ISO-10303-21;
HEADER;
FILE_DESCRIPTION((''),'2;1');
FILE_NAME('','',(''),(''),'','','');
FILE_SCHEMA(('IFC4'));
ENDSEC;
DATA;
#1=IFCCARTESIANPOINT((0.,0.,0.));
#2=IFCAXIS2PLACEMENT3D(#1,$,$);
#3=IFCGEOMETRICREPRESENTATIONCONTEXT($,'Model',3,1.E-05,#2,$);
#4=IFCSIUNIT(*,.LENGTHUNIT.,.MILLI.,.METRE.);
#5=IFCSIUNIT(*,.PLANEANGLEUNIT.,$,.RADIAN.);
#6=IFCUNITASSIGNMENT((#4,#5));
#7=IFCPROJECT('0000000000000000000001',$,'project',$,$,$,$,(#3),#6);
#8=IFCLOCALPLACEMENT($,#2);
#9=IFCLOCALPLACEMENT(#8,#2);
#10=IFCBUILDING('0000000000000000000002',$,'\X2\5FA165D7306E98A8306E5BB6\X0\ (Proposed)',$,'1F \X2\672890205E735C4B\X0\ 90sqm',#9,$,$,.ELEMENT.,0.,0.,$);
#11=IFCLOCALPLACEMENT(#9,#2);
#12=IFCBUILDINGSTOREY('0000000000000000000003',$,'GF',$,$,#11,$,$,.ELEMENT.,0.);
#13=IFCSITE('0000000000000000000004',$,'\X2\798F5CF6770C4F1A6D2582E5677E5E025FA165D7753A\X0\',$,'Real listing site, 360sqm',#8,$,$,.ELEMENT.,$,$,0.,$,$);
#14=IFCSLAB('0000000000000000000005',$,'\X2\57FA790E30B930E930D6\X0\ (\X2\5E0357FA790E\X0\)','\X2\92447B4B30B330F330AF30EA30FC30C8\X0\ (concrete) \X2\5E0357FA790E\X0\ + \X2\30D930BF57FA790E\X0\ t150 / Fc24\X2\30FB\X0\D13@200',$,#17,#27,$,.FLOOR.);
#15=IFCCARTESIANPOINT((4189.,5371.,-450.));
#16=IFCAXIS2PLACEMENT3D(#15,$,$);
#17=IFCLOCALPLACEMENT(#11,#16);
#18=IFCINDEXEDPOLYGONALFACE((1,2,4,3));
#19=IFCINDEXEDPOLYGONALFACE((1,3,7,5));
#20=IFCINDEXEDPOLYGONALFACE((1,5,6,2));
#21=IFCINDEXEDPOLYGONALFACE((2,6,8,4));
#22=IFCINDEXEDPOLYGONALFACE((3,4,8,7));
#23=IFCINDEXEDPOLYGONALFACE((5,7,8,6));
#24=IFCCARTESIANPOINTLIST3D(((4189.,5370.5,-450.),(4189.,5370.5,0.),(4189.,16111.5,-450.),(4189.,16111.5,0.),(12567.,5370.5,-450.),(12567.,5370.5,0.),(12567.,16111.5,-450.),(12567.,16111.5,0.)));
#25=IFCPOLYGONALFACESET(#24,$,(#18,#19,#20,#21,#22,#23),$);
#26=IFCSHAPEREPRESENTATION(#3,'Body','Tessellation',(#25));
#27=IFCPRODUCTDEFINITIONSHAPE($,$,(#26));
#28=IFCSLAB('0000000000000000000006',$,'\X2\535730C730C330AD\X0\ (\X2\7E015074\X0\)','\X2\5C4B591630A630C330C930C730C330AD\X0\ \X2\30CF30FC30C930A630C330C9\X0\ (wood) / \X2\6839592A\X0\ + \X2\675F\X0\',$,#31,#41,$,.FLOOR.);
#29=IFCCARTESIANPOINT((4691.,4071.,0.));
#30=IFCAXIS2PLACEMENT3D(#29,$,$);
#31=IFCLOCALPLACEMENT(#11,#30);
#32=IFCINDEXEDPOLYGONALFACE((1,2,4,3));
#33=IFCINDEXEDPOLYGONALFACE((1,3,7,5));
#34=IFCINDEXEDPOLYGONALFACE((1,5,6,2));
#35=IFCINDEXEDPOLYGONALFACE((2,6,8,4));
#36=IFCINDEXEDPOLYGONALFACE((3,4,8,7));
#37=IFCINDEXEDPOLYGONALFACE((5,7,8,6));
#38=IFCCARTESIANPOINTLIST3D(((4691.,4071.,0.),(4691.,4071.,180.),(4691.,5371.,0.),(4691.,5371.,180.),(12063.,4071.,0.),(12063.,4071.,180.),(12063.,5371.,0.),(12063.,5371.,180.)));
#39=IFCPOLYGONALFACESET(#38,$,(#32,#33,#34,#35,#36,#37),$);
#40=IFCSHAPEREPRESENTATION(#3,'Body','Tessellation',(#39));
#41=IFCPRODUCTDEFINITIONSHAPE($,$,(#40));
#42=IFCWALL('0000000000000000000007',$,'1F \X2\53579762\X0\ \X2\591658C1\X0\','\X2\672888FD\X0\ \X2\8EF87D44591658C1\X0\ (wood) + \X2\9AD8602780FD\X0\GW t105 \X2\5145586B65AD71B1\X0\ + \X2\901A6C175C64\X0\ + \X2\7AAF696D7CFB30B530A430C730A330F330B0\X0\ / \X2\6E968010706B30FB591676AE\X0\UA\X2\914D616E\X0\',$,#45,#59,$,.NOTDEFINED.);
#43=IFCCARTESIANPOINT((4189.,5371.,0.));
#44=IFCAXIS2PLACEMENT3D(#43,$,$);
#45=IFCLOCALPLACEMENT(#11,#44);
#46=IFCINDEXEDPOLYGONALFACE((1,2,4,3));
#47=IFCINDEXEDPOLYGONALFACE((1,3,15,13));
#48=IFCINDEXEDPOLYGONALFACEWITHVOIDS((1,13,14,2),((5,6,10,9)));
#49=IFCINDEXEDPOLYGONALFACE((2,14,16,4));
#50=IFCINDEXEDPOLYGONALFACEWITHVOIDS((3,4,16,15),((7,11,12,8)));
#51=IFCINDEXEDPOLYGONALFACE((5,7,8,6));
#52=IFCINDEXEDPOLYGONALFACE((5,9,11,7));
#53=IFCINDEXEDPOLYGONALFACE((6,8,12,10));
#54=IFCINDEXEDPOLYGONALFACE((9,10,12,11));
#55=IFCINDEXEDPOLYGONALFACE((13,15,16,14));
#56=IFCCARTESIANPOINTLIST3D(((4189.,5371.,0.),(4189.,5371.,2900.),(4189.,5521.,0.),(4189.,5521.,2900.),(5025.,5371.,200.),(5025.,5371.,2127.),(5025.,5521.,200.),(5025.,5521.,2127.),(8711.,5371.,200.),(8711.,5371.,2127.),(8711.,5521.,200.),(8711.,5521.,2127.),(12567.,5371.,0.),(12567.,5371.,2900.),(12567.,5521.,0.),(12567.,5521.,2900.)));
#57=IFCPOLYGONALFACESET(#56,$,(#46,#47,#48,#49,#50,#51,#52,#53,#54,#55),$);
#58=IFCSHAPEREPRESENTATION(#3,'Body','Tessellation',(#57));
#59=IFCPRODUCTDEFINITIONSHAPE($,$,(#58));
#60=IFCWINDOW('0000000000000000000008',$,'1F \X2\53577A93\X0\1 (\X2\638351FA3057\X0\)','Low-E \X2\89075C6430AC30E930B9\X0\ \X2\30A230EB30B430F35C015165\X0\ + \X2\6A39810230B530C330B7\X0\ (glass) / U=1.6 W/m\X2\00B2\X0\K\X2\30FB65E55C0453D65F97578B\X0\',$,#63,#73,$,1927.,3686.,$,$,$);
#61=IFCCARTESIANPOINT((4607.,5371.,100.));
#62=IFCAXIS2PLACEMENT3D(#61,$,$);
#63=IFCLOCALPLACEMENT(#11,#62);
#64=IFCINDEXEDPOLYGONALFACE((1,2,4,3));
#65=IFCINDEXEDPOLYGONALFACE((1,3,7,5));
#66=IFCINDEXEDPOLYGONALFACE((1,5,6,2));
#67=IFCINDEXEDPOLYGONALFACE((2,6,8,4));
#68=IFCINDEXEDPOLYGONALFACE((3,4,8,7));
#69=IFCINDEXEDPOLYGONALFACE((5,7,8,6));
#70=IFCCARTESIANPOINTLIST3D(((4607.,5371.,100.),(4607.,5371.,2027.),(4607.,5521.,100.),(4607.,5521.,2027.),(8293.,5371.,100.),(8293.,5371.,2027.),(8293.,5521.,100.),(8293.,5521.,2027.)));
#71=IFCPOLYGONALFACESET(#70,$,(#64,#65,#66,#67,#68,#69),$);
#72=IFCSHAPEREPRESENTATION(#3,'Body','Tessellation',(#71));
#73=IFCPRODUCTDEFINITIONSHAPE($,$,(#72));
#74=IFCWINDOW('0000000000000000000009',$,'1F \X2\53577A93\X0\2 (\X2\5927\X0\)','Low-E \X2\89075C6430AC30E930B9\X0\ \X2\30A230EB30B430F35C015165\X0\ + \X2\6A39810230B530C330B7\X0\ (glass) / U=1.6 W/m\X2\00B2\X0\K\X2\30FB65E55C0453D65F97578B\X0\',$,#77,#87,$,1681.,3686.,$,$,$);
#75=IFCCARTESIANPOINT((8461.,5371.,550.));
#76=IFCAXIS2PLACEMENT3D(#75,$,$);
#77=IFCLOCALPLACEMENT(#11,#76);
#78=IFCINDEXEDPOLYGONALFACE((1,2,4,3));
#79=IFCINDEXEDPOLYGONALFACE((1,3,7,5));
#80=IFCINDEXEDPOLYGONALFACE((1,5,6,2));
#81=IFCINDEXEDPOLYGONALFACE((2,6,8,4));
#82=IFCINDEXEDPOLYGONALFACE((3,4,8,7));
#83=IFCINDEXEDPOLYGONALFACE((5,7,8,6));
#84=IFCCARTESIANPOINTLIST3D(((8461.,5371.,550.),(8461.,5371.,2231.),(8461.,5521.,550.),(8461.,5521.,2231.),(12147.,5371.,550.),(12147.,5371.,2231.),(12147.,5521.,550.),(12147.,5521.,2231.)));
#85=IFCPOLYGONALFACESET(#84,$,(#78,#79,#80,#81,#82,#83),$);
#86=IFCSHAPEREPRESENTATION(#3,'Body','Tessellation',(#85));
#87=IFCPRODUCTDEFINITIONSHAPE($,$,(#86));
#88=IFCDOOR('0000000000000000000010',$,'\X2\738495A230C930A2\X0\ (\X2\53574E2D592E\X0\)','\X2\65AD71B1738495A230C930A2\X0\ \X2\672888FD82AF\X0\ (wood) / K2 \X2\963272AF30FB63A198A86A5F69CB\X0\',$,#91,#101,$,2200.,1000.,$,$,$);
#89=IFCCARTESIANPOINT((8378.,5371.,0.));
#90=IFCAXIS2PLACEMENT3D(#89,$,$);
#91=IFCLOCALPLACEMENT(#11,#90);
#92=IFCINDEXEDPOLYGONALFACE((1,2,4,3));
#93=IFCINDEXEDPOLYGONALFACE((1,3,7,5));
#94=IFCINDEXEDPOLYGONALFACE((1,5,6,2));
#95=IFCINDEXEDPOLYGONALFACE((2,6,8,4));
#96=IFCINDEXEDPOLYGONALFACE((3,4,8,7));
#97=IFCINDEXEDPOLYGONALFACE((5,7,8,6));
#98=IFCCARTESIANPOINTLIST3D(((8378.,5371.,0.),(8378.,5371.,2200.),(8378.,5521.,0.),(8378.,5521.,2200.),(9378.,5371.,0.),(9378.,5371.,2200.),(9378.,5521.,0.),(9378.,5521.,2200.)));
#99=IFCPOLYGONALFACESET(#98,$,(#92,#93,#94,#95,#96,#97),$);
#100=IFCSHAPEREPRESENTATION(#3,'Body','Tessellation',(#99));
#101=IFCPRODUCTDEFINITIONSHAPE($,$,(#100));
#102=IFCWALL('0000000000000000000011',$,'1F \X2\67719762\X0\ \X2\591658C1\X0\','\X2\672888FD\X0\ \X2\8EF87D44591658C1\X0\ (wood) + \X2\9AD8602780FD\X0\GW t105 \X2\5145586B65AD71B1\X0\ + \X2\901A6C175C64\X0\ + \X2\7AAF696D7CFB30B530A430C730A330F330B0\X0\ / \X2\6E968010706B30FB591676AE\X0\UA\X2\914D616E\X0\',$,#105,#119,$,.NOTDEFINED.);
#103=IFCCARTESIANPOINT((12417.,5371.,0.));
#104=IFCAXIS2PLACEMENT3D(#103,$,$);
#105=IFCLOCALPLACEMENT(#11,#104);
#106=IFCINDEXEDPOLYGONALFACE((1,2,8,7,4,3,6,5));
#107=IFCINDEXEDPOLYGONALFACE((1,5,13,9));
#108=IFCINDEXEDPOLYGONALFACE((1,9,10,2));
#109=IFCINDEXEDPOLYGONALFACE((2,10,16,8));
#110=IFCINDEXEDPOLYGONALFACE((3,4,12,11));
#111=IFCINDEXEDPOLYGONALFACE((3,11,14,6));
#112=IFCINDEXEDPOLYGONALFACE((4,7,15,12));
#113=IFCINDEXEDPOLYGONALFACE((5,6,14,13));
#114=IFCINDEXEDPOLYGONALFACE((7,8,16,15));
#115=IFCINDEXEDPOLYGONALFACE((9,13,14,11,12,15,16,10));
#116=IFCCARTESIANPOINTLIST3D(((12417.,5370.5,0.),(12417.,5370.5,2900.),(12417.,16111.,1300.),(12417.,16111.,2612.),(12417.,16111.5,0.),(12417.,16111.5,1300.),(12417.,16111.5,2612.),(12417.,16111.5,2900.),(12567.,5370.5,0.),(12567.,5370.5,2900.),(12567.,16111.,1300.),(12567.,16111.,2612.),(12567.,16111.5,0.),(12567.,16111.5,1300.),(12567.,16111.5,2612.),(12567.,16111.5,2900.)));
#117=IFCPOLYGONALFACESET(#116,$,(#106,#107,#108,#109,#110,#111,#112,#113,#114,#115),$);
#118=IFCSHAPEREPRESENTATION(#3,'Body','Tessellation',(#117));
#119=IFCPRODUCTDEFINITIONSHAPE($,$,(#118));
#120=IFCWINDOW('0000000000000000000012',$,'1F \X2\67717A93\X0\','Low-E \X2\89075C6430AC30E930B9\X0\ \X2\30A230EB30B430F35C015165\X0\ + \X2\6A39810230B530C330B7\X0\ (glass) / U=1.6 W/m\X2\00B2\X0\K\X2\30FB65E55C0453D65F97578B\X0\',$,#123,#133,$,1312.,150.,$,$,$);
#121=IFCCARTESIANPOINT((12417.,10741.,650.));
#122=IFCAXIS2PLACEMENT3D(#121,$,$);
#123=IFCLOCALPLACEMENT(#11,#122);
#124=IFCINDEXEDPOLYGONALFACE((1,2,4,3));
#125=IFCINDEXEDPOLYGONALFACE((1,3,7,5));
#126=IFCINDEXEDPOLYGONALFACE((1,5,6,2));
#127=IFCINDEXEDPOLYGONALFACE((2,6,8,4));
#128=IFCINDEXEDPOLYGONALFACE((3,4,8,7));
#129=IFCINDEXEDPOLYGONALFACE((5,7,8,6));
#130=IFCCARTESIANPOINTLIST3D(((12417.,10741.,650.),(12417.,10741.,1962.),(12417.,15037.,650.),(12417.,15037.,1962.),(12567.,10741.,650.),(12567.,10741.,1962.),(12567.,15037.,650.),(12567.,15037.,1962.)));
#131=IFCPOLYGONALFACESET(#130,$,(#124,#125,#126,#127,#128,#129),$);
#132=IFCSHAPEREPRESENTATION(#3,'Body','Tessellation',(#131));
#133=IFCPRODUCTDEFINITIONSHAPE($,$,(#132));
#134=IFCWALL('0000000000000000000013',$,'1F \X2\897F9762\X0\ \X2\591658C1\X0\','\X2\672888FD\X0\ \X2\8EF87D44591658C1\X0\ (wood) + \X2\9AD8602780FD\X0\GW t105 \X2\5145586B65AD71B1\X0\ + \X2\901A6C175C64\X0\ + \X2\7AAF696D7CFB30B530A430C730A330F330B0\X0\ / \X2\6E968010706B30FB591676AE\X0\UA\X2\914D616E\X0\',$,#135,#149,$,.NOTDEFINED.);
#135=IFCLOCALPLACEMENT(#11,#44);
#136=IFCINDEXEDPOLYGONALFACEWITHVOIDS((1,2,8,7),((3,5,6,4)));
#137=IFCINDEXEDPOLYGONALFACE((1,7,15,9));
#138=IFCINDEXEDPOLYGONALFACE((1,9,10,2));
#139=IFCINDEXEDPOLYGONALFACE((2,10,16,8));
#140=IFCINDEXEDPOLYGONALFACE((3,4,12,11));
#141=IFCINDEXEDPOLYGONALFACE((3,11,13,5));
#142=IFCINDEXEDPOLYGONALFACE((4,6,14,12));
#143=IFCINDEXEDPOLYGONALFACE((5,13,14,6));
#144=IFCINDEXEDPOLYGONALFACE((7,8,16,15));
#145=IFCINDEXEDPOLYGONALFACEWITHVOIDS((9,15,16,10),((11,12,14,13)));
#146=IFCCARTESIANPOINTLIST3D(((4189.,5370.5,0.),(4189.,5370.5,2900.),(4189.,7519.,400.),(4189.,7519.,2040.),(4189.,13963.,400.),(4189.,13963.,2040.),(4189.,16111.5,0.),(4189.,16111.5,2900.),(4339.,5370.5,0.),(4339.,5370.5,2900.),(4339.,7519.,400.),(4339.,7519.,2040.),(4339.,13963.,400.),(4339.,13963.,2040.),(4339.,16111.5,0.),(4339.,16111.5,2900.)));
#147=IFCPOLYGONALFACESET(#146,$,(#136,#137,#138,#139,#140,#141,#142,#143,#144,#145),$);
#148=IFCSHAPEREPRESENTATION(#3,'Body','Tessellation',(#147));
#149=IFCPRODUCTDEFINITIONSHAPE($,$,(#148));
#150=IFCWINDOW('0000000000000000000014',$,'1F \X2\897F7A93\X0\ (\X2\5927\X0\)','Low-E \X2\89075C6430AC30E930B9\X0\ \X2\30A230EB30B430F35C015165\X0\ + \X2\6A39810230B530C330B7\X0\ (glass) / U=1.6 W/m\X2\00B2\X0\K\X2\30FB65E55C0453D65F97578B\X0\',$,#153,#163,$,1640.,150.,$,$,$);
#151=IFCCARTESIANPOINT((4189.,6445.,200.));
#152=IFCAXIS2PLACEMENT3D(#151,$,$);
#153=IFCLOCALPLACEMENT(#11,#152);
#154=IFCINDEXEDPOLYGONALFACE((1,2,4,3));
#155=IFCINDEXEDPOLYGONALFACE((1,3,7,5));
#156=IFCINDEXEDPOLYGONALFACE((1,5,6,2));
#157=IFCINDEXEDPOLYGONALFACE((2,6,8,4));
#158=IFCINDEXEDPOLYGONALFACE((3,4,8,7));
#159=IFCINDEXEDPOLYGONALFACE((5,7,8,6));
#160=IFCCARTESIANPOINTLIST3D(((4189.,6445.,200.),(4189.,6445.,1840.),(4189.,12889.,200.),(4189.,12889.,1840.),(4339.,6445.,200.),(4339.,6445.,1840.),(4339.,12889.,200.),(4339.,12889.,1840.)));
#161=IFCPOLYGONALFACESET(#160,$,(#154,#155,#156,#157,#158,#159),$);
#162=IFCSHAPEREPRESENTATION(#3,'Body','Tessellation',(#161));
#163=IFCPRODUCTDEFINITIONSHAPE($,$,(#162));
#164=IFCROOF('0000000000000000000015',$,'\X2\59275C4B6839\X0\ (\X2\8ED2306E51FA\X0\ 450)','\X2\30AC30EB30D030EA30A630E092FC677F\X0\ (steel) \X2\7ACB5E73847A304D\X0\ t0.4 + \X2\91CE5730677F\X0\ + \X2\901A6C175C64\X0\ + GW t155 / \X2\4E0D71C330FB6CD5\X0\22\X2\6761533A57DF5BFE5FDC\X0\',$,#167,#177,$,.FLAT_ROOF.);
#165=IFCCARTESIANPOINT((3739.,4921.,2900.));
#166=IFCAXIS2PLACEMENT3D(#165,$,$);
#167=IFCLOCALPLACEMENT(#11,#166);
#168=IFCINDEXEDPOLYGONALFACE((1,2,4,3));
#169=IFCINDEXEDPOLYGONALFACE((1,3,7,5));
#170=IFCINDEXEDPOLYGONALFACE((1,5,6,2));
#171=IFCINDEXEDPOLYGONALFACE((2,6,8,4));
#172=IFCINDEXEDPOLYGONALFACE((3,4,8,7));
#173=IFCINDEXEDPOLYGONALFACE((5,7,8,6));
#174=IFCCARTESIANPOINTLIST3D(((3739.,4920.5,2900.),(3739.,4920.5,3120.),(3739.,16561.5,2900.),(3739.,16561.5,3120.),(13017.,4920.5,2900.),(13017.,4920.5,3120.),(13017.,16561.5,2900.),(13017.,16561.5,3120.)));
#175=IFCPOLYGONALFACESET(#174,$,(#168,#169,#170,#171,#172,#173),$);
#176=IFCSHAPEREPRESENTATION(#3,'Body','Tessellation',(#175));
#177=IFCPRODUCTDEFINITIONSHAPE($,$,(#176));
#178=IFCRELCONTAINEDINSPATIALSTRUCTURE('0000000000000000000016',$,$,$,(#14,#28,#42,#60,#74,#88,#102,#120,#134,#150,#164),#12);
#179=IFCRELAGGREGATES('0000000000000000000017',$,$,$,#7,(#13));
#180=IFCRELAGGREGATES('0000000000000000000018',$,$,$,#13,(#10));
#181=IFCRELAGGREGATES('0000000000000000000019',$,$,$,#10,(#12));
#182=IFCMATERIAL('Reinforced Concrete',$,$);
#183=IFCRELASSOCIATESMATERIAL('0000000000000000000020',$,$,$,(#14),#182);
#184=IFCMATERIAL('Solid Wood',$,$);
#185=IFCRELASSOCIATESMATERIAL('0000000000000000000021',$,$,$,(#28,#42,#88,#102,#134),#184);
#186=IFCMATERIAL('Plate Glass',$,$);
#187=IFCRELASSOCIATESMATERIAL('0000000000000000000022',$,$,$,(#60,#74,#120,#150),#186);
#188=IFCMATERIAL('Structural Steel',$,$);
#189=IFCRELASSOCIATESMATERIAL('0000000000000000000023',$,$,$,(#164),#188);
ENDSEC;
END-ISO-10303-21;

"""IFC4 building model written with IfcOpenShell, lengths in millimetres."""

from ifc_helpers import new_model, si_unit, frame, frame_2d, origin, place, context, project, spatial, rectangle, extrude, material, element, fill, save


model = new_model("IFC4")

# Units and contexts
model_context = context("Model", 3, precision=1e-05, world=origin())
ifc_project = project(units=[si_unit("LENGTHUNIT", "METRE", prefix="MILLI"), si_unit("PLANEANGLEUNIT", "RADIAN")], contexts=[model_context])

# Site, building, storey
site_placement = place(None, origin())
site = spatial("IfcSite", under=ifc_project, at=site_placement, Name="福島県会津若松市御旗町", ObjectType="Real listing site, 360sqm", CompositionType="ELEMENT", RefElevation=0.0)
building_placement = place(site_placement, origin())
building = spatial("IfcBuilding", under=site, at=building_placement, Name="御旗の風の家 (Proposed)", ObjectType="1F 木造平屋 90sqm", CompositionType="ELEMENT", ElevationOfRefHeight=0.0, ElevationOfTerrain=0.0)
storey_placement = place(building_placement, origin())
storey = spatial("IfcBuildingStorey", under=building, at=storey_placement, Name="GF", CompositionType="ELEMENT", Elevation=0.0)

# Slabs
ifc_material_1 = material(Name="Reinforced Concrete")
slab_1_placement = place(storey_placement, frame((4189.0, 5371.0, -450.0)))
element("IfcSlab", 1, at=slab_1_placement, inside=storey, material=ifc_material_1, Name="基礎スラブ (布基礎)", Description="鉄筋コンクリート (concrete) 布基礎 + ベタ基礎 t150 / Fc24・D13@200", PredefinedType="FLOOR", context=model_context, shape_type="SweptSolid", body=[
    extrude(rectangle(XDim=8378.0, YDim=10741.0, at=frame_2d((4189.0, 5370.0))), frame((4189.0, 5371.0, -450.0)), (0.0, 0.0, 1.0), 450.0),
])
ifc_material_2 = material(Name="Solid Wood")
slab_2_placement = place(storey_placement, frame((4691.0, 4071.0, 0.0)))
element("IfcSlab", 2, at=slab_2_placement, inside=storey, material=ifc_material_2, Name="南デッキ (縁側)", Description="屋外ウッドデッキ ハードウッド (wood) / 根太 + 束", PredefinedType="FLOOR", context=model_context, shape_type="SweptSolid", body=[
    extrude(rectangle(XDim=7372.0, YDim=1300.0, at=frame_2d((3686.0, 650.0))), frame((4691.0, 4071.0, 0.0)), (0.0, 0.0, 1.0), 180.0),
])

# Wall, openings, windows, door
wall_1_placement = place(storey_placement, frame((4189.0, 5371.0, 0.0)))
wall_1 = element("IfcWall", 3, at=wall_1_placement, inside=storey, material=ifc_material_2, Name="1F 南面 外壁", Description="木製 軸組外壁 (wood) + 高性能GW t105 充填断熱 + 通気層 + 窯業系サイディング / 準耐火・外皮UA配慮", PredefinedType="NOTDEFINED", context=model_context, shape_type="SweptSolid", body=[
    extrude(rectangle(XDim=8378.0, YDim=150.0, at=frame_2d((4189.0, 75.0))), frame((4189.0, 5371.0, 0.0)), (0.0, 0.0, 1.0), 2900.0),
])
opening_1_placement = place(storey_placement, frame((4607.0, 5371.0, 100.0)))
opening_1 = element("IfcOpeningElement", 4, at=opening_1_placement, cuts=wall_1, PredefinedType="NOTDEFINED", context=model_context, shape_type="SweptSolid", body=[
    extrude(rectangle(XDim=3686.0, YDim=150.0, at=frame_2d((1843.0, 75.0))), frame((4607.0, 5371.0, 100.0)), (0.0, 0.0, 1.0), 1927.0),
])
opening_2_placement = place(storey_placement, frame((8461.0, 5371.0, 550.0)))
opening_2 = element("IfcOpeningElement", 5, at=opening_2_placement, cuts=wall_1, PredefinedType="NOTDEFINED", context=model_context, shape_type="SweptSolid", body=[
    extrude(rectangle(XDim=3686.0, YDim=150.0, at=frame_2d((1843.0, 75.0))), frame((8461.0, 5371.0, 550.0)), (0.0, 0.0, 1.0), 1681.0),
])
opening_3_placement = place(storey_placement, frame((8378.0, 5371.0, 0.0)))
opening_3 = element("IfcOpeningElement", 6, at=opening_3_placement, cuts=wall_1, PredefinedType="NOTDEFINED", context=model_context, shape_type="SweptSolid", body=[
    extrude(rectangle(XDim=1000.0, YDim=150.0, at=frame_2d((500.0, 75.0))), frame((8378.0, 5371.0, 0.0)), (0.0, 0.0, 1.0), 2200.0),
])
ifc_material_3 = material(Name="Plate Glass")
window_1_placement = place(storey_placement, frame((4607.0, 5371.0, 100.0)))
window_1 = element("IfcWindow", 7, at=window_1_placement, inside=storey, material=ifc_material_3, Name="1F 南窓1 (掃出し)", Description="Low-E 複層ガラス アルゴン封入 + 樹脂サッシ (glass) / U=1.6 W/m²K・日射取得型", OverallHeight=1927.0, OverallWidth=3686.0, context=model_context, shape_type="SweptSolid", body=[
    extrude(rectangle(XDim=3686.0, YDim=150.0, at=frame_2d((1843.0, 75.0))), frame((4607.0, 5371.0, 100.0)), (0.0, 0.0, 1.0), 1927.0),
])
fill(opening_1, window_1)
window_2_placement = place(storey_placement, frame((8461.0, 5371.0, 550.0)))
window_2 = element("IfcWindow", 8, at=window_2_placement, inside=storey, material=ifc_material_3, Name="1F 南窓2 (大)", Description="Low-E 複層ガラス アルゴン封入 + 樹脂サッシ (glass) / U=1.6 W/m²K・日射取得型", OverallHeight=1681.0, OverallWidth=3686.0, context=model_context, shape_type="SweptSolid", body=[
    extrude(rectangle(XDim=3686.0, YDim=150.0, at=frame_2d((1843.0, 75.0))), frame((8461.0, 5371.0, 550.0)), (0.0, 0.0, 1.0), 1681.0),
])
fill(opening_2, window_2)
door_placement = place(storey_placement, frame((8378.0, 5371.0, 0.0)))
door = element("IfcDoor", 9, at=door_placement, inside=storey, material=ifc_material_2, Name="玄関ドア (南中央)", Description="断熱玄関ドア 木製芯 (wood) / K2 防犯・採風機構", OverallHeight=2200.0, OverallWidth=1000.0, context=model_context, shape_type="SweptSolid", body=[
    extrude(rectangle(XDim=1000.0, YDim=150.0, at=frame_2d((500.0, 75.0))), frame((8378.0, 5371.0, 0.0)), (0.0, 0.0, 1.0), 2200.0),
])
fill(opening_3, door)

# Walls, openings, windows
wall_2_placement = place(storey_placement, frame((12417.0, 5371.0, 0.0)))
wall_2 = element("IfcWall", 10, at=wall_2_placement, inside=storey, material=ifc_material_2, Name="1F 東面 外壁", Description="木製 軸組外壁 (wood) + 高性能GW t105 充填断熱 + 通気層 + 窯業系サイディング / 準耐火・外皮UA配慮", PredefinedType="NOTDEFINED", context=model_context, shape_type="SweptSolid", body=[
    extrude(rectangle(XDim=150.0, YDim=10741.0, at=frame_2d((75.0, 5370.0))), frame((12417.0, 5371.0, 0.0)), (0.0, 0.0, 1.0), 2900.0),
])
opening_4_placement = place(storey_placement, frame((12417.0, 10741.0, 650.0)))
opening_4 = element("IfcOpeningElement", 11, at=opening_4_placement, cuts=wall_2, PredefinedType="NOTDEFINED", context=model_context, shape_type="SweptSolid", body=[
    extrude(rectangle(XDim=150.0, YDim=4296.0, at=frame_2d((75.0, 2148.0))), frame((12417.0, 10741.0, 650.0)), (0.0, 0.0, 1.0), 1312.0),
])
window_3_placement = place(storey_placement, frame((12417.0, 10741.0, 650.0)))
window_3 = element("IfcWindow", 12, at=window_3_placement, inside=storey, material=ifc_material_3, Name="1F 東窓", Description="Low-E 複層ガラス アルゴン封入 + 樹脂サッシ (glass) / U=1.6 W/m²K・日射取得型", OverallHeight=1312.0, OverallWidth=150.0, context=model_context, shape_type="SweptSolid", body=[
    extrude(rectangle(XDim=150.0, YDim=4296.0, at=frame_2d((75.0, 2148.0))), frame((12417.0, 10741.0, 650.0)), (0.0, 0.0, 1.0), 1312.0),
])
fill(opening_4, window_3)
wall_3_placement = place(storey_placement, frame((4189.0, 5371.0, 0.0)))
wall_3 = element("IfcWall", 13, at=wall_3_placement, inside=storey, material=ifc_material_2, Name="1F 西面 外壁", Description="木製 軸組外壁 (wood) + 高性能GW t105 充填断熱 + 通気層 + 窯業系サイディング / 準耐火・外皮UA配慮", PredefinedType="NOTDEFINED", context=model_context, shape_type="SweptSolid", body=[
    extrude(rectangle(XDim=150.0, YDim=10741.0, at=frame_2d((75.0, 5370.0))), frame((4189.0, 5371.0, 0.0)), (0.0, 0.0, 1.0), 2900.0),
])
opening_5_placement = place(storey_placement, frame((4189.0, 6445.0, 200.0)))
opening_5 = element("IfcOpeningElement", 14, at=opening_5_placement, cuts=wall_3, PredefinedType="NOTDEFINED", context=model_context, shape_type="SweptSolid", body=[
    extrude(rectangle(XDim=150.0, YDim=6444.0, at=frame_2d((75.0, 3222.0))), frame((4189.0, 6445.0, 200.0)), (0.0, 0.0, 1.0), 1640.0),
])
window_4_placement = place(storey_placement, frame((4189.0, 6445.0, 200.0)))
window_4 = element("IfcWindow", 15, at=window_4_placement, inside=storey, material=ifc_material_3, Name="1F 西窓 (大)", Description="Low-E 複層ガラス アルゴン封入 + 樹脂サッシ (glass) / U=1.6 W/m²K・日射取得型", OverallHeight=1640.0, OverallWidth=150.0, context=model_context, shape_type="SweptSolid", body=[
    extrude(rectangle(XDim=150.0, YDim=6444.0, at=frame_2d((75.0, 3222.0))), frame((4189.0, 6445.0, 200.0)), (0.0, 0.0, 1.0), 1640.0),
])
fill(opening_5, window_4)

# Roof
ifc_material_4 = material(Name="Structural Steel")
roof_placement = place(storey_placement, frame((3739.0, 4921.0, 2900.0)))
element("IfcRoof", 16, at=roof_placement, inside=storey, material=ifc_material_4, Name="大屋根 (軒の出 450)", Description="ガルバリウム鋼板 (steel) 立平葺き t0.4 + 野地板 + 通気層 + GW t155 / 不燃・法22条区域対応", PredefinedType="FLAT_ROOF", context=model_context, shape_type="SweptSolid", body=[
    extrude(rectangle(XDim=9278.0, YDim=11641.0, at=frame_2d((4639.0, 5820.0))), frame((3739.0, 4921.0, 2900.0)), (0.0, 0.0, 1.0), 220.0),
])

save(model, "model.ifc")
